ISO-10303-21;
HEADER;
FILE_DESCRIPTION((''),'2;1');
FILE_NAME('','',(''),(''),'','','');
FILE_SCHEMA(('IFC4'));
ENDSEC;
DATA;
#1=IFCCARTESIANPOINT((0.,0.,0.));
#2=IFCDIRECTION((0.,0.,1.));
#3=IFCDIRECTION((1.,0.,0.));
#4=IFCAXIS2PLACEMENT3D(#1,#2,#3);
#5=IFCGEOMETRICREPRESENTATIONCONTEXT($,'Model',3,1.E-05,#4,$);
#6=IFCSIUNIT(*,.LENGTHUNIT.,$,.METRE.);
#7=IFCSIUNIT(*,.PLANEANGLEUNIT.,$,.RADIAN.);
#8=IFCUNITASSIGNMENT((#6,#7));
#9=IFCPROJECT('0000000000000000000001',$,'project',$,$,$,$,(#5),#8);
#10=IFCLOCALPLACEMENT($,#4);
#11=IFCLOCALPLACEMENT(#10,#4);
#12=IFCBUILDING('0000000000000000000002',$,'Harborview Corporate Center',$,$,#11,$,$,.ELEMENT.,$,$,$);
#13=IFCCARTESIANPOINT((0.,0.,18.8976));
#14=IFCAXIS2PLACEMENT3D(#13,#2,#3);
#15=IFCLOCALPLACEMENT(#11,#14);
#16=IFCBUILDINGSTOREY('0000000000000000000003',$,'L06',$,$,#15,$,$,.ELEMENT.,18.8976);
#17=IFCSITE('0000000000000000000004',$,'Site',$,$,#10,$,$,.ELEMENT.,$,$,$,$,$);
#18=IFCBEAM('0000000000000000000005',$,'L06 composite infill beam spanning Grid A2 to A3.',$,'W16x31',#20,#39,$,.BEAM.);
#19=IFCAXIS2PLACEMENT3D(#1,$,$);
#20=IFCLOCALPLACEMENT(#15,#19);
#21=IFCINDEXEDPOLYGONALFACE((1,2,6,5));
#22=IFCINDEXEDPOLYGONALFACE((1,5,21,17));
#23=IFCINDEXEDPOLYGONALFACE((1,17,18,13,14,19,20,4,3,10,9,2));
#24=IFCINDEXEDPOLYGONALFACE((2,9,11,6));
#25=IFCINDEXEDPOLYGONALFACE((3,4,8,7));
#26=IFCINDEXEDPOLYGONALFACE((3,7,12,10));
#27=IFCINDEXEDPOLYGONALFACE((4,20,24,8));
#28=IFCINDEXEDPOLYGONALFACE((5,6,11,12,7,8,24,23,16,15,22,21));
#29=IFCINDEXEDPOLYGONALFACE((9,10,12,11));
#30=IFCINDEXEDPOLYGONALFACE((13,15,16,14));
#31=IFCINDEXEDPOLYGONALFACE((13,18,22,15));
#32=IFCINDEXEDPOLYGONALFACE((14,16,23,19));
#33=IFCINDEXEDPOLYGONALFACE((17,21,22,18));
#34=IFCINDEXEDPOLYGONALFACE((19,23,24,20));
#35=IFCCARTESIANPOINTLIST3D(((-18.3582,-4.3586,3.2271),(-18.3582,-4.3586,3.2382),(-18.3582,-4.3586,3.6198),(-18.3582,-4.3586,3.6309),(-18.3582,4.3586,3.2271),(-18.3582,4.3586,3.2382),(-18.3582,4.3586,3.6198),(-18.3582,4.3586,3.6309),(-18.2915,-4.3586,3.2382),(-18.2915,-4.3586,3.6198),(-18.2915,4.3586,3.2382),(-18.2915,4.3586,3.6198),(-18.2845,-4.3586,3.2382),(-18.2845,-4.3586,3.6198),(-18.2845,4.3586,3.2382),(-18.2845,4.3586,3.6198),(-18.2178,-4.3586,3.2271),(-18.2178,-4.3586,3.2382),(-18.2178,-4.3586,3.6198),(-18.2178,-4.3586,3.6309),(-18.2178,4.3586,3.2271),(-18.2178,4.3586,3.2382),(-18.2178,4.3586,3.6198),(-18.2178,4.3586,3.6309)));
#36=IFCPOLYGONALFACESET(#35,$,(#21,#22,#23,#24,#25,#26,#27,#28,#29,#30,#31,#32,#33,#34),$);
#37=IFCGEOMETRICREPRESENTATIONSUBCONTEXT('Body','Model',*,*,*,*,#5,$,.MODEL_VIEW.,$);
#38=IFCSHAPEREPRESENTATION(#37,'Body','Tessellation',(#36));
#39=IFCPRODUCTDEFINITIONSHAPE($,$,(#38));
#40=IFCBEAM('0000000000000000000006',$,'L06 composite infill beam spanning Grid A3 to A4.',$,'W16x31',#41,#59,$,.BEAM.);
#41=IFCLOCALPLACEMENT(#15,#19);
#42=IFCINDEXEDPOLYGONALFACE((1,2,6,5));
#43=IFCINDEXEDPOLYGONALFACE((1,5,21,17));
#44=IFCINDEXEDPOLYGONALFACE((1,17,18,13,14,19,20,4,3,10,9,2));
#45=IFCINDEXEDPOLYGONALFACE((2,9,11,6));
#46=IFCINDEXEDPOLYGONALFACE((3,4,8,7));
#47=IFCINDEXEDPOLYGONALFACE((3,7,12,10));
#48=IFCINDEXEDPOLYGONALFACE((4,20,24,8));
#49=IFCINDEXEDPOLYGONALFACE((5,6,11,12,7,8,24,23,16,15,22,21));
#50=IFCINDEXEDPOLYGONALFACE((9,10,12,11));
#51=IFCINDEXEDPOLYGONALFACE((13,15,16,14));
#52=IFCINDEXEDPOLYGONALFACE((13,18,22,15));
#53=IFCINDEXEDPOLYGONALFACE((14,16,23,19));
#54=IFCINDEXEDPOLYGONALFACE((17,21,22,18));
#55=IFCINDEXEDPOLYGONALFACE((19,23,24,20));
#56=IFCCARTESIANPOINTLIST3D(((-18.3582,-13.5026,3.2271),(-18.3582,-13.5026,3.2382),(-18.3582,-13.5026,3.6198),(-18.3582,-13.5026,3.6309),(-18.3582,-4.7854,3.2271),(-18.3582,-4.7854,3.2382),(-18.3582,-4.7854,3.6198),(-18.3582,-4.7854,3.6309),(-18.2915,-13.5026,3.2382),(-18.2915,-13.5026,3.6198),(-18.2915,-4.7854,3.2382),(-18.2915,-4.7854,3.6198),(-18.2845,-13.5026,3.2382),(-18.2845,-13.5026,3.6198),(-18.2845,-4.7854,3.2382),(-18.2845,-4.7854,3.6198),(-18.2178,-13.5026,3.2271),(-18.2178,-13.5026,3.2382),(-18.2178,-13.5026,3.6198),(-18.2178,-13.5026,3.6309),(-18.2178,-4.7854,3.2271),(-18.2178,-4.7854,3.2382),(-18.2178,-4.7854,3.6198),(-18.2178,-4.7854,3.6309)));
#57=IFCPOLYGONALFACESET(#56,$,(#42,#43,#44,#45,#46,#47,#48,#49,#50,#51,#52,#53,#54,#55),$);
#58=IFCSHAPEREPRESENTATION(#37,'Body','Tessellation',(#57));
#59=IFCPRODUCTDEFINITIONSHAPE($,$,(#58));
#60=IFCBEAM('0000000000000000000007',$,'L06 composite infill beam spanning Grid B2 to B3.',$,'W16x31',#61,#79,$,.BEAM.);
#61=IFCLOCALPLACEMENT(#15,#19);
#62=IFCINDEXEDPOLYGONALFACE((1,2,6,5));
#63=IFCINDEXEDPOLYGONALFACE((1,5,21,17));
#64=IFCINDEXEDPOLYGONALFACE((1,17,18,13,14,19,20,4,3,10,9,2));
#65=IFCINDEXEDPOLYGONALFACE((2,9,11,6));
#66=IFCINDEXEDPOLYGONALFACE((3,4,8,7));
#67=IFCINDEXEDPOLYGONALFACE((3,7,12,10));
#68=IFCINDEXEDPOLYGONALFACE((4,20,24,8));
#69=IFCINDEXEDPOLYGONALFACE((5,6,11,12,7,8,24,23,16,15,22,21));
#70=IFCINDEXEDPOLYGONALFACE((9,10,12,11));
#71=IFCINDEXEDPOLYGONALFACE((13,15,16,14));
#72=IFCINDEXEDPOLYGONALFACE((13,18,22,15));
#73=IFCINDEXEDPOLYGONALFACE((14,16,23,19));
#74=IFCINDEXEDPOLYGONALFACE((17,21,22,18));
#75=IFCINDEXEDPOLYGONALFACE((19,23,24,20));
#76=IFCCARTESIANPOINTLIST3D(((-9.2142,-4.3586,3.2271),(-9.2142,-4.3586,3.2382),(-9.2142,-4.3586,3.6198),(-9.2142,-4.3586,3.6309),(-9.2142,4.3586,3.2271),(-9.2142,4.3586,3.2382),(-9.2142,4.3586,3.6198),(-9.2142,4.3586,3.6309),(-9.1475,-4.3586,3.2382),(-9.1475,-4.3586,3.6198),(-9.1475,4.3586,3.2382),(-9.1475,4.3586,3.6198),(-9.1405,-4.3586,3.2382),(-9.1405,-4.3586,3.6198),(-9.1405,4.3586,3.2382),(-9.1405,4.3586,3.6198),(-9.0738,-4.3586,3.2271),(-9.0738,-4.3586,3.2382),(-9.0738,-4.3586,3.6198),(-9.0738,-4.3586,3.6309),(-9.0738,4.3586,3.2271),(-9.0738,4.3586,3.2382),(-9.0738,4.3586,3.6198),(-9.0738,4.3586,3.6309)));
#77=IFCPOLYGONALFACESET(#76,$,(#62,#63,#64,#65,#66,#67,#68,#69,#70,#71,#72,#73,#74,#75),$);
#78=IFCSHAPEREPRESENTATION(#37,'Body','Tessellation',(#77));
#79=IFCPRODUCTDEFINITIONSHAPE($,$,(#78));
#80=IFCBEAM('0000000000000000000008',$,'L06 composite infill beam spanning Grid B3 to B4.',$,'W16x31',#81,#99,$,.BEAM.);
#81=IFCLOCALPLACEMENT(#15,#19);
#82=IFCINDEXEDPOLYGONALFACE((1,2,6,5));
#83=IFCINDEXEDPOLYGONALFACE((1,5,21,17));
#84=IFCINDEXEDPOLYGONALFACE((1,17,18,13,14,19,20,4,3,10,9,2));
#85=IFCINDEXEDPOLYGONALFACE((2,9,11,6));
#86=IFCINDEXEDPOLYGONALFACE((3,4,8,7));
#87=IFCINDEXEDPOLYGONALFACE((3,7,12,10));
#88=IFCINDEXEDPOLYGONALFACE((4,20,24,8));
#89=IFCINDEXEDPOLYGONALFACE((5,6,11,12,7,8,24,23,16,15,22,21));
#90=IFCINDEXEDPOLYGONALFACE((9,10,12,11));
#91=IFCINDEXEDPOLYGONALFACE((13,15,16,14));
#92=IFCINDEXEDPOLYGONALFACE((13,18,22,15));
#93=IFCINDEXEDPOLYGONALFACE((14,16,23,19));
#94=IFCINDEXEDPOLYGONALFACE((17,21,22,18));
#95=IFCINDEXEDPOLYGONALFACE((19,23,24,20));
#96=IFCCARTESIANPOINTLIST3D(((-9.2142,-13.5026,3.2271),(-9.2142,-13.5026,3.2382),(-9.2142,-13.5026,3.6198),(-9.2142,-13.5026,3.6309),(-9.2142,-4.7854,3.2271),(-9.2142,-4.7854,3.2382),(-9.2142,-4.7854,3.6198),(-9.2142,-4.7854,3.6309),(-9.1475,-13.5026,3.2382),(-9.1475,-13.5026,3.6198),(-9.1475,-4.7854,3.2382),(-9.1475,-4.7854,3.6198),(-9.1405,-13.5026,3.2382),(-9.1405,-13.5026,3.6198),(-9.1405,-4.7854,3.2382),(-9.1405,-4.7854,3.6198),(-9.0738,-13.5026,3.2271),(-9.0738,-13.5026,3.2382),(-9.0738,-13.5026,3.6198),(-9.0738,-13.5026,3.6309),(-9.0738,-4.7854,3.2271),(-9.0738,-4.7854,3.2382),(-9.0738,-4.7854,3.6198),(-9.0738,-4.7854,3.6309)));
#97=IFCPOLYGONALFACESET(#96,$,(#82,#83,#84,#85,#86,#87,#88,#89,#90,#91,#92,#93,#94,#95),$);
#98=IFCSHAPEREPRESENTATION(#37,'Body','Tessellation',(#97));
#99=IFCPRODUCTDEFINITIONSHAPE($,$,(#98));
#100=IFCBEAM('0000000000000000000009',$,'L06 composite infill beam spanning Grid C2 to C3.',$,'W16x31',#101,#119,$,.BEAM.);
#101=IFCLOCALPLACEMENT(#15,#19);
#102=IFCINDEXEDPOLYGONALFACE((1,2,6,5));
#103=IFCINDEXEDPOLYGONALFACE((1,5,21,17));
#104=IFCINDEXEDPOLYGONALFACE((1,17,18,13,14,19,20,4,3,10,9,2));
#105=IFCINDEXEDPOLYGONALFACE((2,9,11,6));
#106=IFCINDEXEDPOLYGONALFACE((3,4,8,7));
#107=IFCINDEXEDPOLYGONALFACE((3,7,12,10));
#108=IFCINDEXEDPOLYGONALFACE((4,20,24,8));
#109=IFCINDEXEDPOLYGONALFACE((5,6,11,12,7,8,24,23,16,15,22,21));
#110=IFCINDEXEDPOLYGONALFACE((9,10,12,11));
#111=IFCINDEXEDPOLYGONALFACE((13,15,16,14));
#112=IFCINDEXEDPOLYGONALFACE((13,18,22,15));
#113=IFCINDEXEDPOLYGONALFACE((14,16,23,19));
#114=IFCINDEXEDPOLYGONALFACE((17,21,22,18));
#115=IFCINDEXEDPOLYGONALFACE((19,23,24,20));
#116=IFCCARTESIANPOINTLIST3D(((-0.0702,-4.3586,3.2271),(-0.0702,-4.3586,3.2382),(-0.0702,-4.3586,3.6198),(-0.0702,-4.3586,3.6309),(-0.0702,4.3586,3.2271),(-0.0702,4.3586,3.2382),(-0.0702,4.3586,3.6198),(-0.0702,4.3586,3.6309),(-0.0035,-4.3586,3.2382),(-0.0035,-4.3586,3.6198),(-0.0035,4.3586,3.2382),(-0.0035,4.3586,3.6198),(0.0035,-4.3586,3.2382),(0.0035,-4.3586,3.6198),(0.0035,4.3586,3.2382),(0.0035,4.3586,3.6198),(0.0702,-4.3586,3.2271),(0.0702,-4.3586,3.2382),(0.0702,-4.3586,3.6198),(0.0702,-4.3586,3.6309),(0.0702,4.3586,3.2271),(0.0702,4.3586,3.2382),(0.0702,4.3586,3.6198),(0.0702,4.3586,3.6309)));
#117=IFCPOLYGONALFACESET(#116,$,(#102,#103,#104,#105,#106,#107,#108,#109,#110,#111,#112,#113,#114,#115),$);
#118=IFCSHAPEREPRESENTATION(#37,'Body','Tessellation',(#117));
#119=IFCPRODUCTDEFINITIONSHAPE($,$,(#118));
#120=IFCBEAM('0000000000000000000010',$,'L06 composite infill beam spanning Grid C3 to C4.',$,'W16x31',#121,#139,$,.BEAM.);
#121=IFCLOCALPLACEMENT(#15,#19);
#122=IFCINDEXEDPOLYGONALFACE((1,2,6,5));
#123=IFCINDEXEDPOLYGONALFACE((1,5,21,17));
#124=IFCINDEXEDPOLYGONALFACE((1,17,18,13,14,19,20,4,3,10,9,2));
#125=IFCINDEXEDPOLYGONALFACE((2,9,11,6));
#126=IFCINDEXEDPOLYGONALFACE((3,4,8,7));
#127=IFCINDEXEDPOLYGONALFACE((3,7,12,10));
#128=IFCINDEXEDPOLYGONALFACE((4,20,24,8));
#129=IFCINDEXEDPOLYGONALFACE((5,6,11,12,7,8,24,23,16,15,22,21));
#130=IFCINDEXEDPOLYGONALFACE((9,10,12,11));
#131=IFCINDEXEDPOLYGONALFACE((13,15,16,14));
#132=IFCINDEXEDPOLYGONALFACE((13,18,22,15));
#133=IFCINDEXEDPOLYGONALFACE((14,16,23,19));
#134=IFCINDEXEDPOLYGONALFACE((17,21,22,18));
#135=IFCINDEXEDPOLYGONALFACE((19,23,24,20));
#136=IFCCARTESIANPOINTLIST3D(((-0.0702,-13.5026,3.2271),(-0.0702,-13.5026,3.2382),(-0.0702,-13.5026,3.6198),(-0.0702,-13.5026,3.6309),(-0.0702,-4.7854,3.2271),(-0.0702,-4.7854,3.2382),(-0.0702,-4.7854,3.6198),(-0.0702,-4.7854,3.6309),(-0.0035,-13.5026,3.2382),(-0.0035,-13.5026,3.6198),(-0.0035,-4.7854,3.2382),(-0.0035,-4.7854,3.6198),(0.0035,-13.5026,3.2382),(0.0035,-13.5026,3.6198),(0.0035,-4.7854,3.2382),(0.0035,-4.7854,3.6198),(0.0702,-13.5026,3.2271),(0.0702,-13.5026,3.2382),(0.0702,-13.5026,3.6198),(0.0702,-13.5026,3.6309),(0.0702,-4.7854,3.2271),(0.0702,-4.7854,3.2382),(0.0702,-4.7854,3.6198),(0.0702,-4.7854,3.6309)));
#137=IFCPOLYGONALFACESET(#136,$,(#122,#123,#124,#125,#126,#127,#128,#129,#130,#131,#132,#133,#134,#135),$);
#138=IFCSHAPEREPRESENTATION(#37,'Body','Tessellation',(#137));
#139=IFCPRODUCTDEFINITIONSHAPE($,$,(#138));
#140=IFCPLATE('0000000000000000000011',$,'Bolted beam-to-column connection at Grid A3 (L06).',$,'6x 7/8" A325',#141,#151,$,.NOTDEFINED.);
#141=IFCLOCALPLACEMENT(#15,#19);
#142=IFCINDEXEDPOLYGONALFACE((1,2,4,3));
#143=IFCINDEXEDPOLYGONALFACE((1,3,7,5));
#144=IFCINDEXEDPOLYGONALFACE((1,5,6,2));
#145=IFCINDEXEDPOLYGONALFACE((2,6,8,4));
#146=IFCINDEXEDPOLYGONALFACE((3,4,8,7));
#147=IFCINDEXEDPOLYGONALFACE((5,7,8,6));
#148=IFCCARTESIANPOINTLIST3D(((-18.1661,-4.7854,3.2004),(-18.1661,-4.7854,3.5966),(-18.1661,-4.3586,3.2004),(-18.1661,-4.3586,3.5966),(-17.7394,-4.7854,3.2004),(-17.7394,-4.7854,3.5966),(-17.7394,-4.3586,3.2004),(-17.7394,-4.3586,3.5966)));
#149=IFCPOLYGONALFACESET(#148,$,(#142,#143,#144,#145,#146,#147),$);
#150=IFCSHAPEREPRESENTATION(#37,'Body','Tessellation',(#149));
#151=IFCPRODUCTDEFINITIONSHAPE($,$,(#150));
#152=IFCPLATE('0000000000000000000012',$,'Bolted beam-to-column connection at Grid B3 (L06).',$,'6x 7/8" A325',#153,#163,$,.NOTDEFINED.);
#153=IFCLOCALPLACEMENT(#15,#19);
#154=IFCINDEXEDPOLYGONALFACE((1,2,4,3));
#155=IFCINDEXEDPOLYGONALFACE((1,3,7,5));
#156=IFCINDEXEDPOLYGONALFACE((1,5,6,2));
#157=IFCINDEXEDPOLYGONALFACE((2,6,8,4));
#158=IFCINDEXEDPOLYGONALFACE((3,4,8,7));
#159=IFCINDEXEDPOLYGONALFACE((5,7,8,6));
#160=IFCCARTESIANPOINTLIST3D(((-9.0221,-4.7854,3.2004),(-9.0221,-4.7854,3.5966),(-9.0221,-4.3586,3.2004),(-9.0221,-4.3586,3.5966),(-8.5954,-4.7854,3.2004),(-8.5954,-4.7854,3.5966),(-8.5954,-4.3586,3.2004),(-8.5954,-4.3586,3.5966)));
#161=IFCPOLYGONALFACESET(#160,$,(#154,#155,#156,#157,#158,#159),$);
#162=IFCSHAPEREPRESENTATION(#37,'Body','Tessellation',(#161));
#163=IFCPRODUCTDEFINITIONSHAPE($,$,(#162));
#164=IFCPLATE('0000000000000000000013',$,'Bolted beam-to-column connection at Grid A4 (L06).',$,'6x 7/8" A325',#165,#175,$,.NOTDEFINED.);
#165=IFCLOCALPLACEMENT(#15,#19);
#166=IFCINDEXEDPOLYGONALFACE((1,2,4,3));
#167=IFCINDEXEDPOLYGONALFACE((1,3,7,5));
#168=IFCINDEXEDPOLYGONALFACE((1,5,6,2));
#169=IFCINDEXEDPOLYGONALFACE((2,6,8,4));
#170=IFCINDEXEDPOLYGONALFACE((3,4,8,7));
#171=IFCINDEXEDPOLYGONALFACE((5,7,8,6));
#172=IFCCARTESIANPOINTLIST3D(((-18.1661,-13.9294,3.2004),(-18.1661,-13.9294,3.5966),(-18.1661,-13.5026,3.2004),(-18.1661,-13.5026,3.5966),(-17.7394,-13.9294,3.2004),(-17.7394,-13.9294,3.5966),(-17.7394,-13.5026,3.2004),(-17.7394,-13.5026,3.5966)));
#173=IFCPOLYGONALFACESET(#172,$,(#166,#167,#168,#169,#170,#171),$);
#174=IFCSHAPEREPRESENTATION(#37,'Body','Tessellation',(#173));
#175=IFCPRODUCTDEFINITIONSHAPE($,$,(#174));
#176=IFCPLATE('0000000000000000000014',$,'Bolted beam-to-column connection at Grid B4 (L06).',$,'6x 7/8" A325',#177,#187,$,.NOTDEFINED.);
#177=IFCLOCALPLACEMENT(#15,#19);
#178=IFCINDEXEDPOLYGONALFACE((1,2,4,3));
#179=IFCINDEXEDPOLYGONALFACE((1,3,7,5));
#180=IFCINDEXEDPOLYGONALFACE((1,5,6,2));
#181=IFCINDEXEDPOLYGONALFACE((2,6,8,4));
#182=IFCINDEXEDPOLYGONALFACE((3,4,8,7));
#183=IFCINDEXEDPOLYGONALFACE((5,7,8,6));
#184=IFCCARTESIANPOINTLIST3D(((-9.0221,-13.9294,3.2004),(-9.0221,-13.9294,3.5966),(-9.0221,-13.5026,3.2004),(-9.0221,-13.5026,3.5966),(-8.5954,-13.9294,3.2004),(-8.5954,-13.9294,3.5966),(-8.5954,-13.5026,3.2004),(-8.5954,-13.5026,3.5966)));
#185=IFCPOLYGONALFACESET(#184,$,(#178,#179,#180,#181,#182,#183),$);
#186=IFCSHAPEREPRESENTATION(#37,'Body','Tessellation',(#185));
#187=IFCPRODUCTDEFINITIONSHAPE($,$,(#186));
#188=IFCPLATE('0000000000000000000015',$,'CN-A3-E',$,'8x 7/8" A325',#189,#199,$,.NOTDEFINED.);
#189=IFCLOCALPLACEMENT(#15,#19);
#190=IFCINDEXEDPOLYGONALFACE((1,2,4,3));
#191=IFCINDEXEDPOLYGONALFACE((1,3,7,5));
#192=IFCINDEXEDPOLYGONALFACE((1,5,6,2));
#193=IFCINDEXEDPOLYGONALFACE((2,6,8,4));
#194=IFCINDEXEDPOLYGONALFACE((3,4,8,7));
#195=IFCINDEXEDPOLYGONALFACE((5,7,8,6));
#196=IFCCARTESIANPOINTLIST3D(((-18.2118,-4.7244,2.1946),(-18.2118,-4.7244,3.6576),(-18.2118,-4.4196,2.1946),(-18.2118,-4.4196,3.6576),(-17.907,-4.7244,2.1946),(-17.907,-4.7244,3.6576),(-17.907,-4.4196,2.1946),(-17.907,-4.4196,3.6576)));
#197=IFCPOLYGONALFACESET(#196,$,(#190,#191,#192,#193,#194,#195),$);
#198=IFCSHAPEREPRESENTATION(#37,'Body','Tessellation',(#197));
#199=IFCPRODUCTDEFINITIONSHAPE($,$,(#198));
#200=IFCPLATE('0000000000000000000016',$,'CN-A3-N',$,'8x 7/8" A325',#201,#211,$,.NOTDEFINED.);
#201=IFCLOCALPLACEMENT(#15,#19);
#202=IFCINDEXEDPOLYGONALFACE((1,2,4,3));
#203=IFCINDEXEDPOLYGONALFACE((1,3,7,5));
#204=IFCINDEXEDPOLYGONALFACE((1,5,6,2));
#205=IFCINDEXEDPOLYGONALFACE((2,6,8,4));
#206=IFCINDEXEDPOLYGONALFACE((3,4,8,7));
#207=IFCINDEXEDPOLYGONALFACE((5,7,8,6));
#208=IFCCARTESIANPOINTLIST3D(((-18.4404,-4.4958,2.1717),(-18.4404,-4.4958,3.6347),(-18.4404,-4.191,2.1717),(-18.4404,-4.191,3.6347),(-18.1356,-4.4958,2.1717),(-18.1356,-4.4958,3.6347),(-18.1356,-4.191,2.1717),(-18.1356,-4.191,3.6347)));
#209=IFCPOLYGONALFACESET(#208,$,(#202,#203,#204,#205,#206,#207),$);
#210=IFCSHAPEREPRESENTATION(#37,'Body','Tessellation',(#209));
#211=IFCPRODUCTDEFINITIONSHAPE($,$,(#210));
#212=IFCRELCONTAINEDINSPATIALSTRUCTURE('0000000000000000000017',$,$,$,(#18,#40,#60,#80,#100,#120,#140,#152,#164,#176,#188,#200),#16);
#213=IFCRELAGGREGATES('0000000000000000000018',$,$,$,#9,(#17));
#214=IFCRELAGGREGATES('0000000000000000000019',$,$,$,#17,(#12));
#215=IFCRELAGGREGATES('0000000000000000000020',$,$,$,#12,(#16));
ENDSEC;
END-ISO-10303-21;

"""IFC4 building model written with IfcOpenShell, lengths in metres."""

from ifc_helpers import new_model, si_unit, frame, origin_with_axes, place, context, subcontext, project, spatial, rectangle, i_section, extrude, element, save


model = new_model("IFC4")

# Units and contexts
model_context = context("Model", 3, precision=1e-05, world=origin_with_axes())
body_context = subcontext(model_context, "Body", "Model", "MODEL_VIEW")
ifc_project = project(units=[si_unit("LENGTHUNIT", "METRE"), si_unit("PLANEANGLEUNIT", "RADIAN")], contexts=[model_context])

# Site, building, storey
site_placement = place(None, origin_with_axes())
site = spatial("IfcSite", under=ifc_project, at=site_placement, Name="Site", CompositionType="ELEMENT")
building_placement = place(site_placement, origin_with_axes())
building = spatial("IfcBuilding", under=site, at=building_placement, Name="Harborview Corporate Center", CompositionType="ELEMENT")
storey_placement = place(building_placement, frame((0.0, 0.0, 18.8976), z_axis=(0.0, 0.0, 1.0), x_axis=(1.0, 0.0, 0.0)))
storey = spatial("IfcBuildingStorey", under=building, at=storey_placement, Name="L06", CompositionType="ELEMENT", Elevation=18.8976)

# Beams
beam_1_placement = place(storey_placement, frame((-18.288, -4.3586, 3.429), z_axis=(0.0, 1.0, 0.0), x_axis=(-1.0, 0.0, 0.0)))
element("IfcBeam", 1, at=beam_1_placement, inside=storey, Name="L06 composite infill beam spanning Grid A2 to A3.", ObjectType="W16x31", PredefinedType="BEAM", context=body_context, shape_type="SweptSolid", body=[
    extrude(i_section(OverallWidth=0.1405, OverallDepth=0.4039, WebThickness=0.007, FlangeThickness=0.0112), origin_with_axes(), (0.0, 0.0, 1.0), 8.7173),
])
beam_2_placement = place(storey_placement, frame((-18.288, -13.5026, 3.429), z_axis=(0.0, 1.0, 0.0), x_axis=(-1.0, 0.0, 0.0)))
element("IfcBeam", 2, at=beam_2_placement, inside=storey, Name="L06 composite infill beam spanning Grid A3 to A4.", ObjectType="W16x31", PredefinedType="BEAM", context=body_context, shape_type="SweptSolid", body=[
    extrude(i_section(OverallWidth=0.1405, OverallDepth=0.4039, WebThickness=0.007, FlangeThickness=0.0112), origin_with_axes(), (0.0, 0.0, 1.0), 8.7173),
])
beam_3_placement = place(storey_placement, frame((-9.144, -4.3586, 3.429), z_axis=(0.0, 1.0, 0.0), x_axis=(-1.0, 0.0, 0.0)))
element("IfcBeam", 3, at=beam_3_placement, inside=storey, Name="L06 composite infill beam spanning Grid B2 to B3.", ObjectType="W16x31", PredefinedType="BEAM", context=body_context, shape_type="SweptSolid", body=[
    extrude(i_section(OverallWidth=0.1405, OverallDepth=0.4039, WebThickness=0.007, FlangeThickness=0.0112), origin_with_axes(), (0.0, 0.0, 1.0), 8.7173),
])
beam_4_placement = place(storey_placement, frame((-9.144, -13.5026, 3.429), z_axis=(0.0, 1.0, 0.0), x_axis=(-1.0, 0.0, 0.0)))
element("IfcBeam", 4, at=beam_4_placement, inside=storey, Name="L06 composite infill beam spanning Grid B3 to B4.", ObjectType="W16x31", PredefinedType="BEAM", context=body_context, shape_type="SweptSolid", body=[
    extrude(i_section(OverallWidth=0.1405, OverallDepth=0.4039, WebThickness=0.007, FlangeThickness=0.0112), origin_with_axes(), (0.0, 0.0, 1.0), 8.7173),
])
beam_5_placement = place(storey_placement, frame((0.0, -4.3586, 3.429), z_axis=(0.0, 1.0, 0.0), x_axis=(-1.0, 0.0, 0.0)))
element("IfcBeam", 5, at=beam_5_placement, inside=storey, Name="L06 composite infill beam spanning Grid C2 to C3.", ObjectType="W16x31", PredefinedType="BEAM", context=body_context, shape_type="SweptSolid", body=[
    extrude(i_section(OverallWidth=0.1405, OverallDepth=0.4039, WebThickness=0.007, FlangeThickness=0.0112), origin_with_axes(), (0.0, 0.0, 1.0), 8.7173),
])
beam_6_placement = place(storey_placement, frame((0.0, -13.5026, 3.429), z_axis=(0.0, 1.0, 0.0), x_axis=(-1.0, 0.0, 0.0)))
element("IfcBeam", 6, at=beam_6_placement, inside=storey, Name="L06 composite infill beam spanning Grid C3 to C4.", ObjectType="W16x31", PredefinedType="BEAM", context=body_context, shape_type="SweptSolid", body=[
    extrude(i_section(OverallWidth=0.1405, OverallDepth=0.4039, WebThickness=0.007, FlangeThickness=0.0112), origin_with_axes(), (0.0, 0.0, 1.0), 8.7173),
])

# Plates
plate_1_placement = place(storey_placement, frame((-17.9527, -4.572, 3.2004), z_axis=(0.0, 0.0, 1.0), x_axis=(1.0, 0.0, 0.0)))
element("IfcPlate", 7, at=plate_1_placement, inside=storey, Name="Bolted beam-to-column connection at Grid A3 (L06).", ObjectType="6x 7/8\" A325", PredefinedType="NOTDEFINED", context=body_context, shape_type="SweptSolid", body=[
    extrude(rectangle(XDim=0.4267, YDim=0.4267), origin_with_axes(), (0.0, 0.0, 1.0), 0.3962),
])
plate_2_placement = place(storey_placement, frame((-8.8087, -4.572, 3.2004), z_axis=(0.0, 0.0, 1.0), x_axis=(1.0, 0.0, 0.0)))
element("IfcPlate", 8, at=plate_2_placement, inside=storey, Name="Bolted beam-to-column connection at Grid B3 (L06).", ObjectType="6x 7/8\" A325", PredefinedType="NOTDEFINED", context=body_context, shape_type="SweptSolid", body=[
    extrude(rectangle(XDim=0.4267, YDim=0.4267), origin_with_axes(), (0.0, 0.0, 1.0), 0.3962),
])
plate_3_placement = place(storey_placement, frame((-17.9527, -13.716, 3.2004), z_axis=(0.0, 0.0, 1.0), x_axis=(1.0, 0.0, 0.0)))
element("IfcPlate", 9, at=plate_3_placement, inside=storey, Name="Bolted beam-to-column connection at Grid A4 (L06).", ObjectType="6x 7/8\" A325", PredefinedType="NOTDEFINED", context=body_context, shape_type="SweptSolid", body=[
    extrude(rectangle(XDim=0.4267, YDim=0.4267), origin_with_axes(), (0.0, 0.0, 1.0), 0.3962),
])
plate_4_placement = place(storey_placement, frame((-8.8087, -13.716, 3.2004), z_axis=(0.0, 0.0, 1.0), x_axis=(1.0, 0.0, 0.0)))
element("IfcPlate", 10, at=plate_4_placement, inside=storey, Name="Bolted beam-to-column connection at Grid B4 (L06).", ObjectType="6x 7/8\" A325", PredefinedType="NOTDEFINED", context=body_context, shape_type="SweptSolid", body=[
    extrude(rectangle(XDim=0.4267, YDim=0.4267), origin_with_axes(), (0.0, 0.0, 1.0), 0.3962),
])
for number, where, z_axis, x_axis, name in (
    (11, (-18.0594, -4.572, 2.1946), (0.0, 0.0, 1.0), (1.0, 0.0, 0.0), "CN-A3-E"),
    (12, (-18.288, -4.3434, 2.1717), (0.0, 0.0, 1.0), (1.0, 0.0, 0.0), "CN-A3-N"),
):
    element("IfcPlate", number, at=place(storey_placement, frame(where, z_axis=z_axis, x_axis=x_axis)), inside=storey, Name=name, ObjectType="8x 7/8\" A325", PredefinedType="NOTDEFINED", context=body_context, shape_type="SweptSolid", body=[
        extrude(rectangle(XDim=0.3048, YDim=0.3048), origin_with_axes(), (0.0, 0.0, 1.0), 1.463),
    ])

save(model, "model.ifc")
